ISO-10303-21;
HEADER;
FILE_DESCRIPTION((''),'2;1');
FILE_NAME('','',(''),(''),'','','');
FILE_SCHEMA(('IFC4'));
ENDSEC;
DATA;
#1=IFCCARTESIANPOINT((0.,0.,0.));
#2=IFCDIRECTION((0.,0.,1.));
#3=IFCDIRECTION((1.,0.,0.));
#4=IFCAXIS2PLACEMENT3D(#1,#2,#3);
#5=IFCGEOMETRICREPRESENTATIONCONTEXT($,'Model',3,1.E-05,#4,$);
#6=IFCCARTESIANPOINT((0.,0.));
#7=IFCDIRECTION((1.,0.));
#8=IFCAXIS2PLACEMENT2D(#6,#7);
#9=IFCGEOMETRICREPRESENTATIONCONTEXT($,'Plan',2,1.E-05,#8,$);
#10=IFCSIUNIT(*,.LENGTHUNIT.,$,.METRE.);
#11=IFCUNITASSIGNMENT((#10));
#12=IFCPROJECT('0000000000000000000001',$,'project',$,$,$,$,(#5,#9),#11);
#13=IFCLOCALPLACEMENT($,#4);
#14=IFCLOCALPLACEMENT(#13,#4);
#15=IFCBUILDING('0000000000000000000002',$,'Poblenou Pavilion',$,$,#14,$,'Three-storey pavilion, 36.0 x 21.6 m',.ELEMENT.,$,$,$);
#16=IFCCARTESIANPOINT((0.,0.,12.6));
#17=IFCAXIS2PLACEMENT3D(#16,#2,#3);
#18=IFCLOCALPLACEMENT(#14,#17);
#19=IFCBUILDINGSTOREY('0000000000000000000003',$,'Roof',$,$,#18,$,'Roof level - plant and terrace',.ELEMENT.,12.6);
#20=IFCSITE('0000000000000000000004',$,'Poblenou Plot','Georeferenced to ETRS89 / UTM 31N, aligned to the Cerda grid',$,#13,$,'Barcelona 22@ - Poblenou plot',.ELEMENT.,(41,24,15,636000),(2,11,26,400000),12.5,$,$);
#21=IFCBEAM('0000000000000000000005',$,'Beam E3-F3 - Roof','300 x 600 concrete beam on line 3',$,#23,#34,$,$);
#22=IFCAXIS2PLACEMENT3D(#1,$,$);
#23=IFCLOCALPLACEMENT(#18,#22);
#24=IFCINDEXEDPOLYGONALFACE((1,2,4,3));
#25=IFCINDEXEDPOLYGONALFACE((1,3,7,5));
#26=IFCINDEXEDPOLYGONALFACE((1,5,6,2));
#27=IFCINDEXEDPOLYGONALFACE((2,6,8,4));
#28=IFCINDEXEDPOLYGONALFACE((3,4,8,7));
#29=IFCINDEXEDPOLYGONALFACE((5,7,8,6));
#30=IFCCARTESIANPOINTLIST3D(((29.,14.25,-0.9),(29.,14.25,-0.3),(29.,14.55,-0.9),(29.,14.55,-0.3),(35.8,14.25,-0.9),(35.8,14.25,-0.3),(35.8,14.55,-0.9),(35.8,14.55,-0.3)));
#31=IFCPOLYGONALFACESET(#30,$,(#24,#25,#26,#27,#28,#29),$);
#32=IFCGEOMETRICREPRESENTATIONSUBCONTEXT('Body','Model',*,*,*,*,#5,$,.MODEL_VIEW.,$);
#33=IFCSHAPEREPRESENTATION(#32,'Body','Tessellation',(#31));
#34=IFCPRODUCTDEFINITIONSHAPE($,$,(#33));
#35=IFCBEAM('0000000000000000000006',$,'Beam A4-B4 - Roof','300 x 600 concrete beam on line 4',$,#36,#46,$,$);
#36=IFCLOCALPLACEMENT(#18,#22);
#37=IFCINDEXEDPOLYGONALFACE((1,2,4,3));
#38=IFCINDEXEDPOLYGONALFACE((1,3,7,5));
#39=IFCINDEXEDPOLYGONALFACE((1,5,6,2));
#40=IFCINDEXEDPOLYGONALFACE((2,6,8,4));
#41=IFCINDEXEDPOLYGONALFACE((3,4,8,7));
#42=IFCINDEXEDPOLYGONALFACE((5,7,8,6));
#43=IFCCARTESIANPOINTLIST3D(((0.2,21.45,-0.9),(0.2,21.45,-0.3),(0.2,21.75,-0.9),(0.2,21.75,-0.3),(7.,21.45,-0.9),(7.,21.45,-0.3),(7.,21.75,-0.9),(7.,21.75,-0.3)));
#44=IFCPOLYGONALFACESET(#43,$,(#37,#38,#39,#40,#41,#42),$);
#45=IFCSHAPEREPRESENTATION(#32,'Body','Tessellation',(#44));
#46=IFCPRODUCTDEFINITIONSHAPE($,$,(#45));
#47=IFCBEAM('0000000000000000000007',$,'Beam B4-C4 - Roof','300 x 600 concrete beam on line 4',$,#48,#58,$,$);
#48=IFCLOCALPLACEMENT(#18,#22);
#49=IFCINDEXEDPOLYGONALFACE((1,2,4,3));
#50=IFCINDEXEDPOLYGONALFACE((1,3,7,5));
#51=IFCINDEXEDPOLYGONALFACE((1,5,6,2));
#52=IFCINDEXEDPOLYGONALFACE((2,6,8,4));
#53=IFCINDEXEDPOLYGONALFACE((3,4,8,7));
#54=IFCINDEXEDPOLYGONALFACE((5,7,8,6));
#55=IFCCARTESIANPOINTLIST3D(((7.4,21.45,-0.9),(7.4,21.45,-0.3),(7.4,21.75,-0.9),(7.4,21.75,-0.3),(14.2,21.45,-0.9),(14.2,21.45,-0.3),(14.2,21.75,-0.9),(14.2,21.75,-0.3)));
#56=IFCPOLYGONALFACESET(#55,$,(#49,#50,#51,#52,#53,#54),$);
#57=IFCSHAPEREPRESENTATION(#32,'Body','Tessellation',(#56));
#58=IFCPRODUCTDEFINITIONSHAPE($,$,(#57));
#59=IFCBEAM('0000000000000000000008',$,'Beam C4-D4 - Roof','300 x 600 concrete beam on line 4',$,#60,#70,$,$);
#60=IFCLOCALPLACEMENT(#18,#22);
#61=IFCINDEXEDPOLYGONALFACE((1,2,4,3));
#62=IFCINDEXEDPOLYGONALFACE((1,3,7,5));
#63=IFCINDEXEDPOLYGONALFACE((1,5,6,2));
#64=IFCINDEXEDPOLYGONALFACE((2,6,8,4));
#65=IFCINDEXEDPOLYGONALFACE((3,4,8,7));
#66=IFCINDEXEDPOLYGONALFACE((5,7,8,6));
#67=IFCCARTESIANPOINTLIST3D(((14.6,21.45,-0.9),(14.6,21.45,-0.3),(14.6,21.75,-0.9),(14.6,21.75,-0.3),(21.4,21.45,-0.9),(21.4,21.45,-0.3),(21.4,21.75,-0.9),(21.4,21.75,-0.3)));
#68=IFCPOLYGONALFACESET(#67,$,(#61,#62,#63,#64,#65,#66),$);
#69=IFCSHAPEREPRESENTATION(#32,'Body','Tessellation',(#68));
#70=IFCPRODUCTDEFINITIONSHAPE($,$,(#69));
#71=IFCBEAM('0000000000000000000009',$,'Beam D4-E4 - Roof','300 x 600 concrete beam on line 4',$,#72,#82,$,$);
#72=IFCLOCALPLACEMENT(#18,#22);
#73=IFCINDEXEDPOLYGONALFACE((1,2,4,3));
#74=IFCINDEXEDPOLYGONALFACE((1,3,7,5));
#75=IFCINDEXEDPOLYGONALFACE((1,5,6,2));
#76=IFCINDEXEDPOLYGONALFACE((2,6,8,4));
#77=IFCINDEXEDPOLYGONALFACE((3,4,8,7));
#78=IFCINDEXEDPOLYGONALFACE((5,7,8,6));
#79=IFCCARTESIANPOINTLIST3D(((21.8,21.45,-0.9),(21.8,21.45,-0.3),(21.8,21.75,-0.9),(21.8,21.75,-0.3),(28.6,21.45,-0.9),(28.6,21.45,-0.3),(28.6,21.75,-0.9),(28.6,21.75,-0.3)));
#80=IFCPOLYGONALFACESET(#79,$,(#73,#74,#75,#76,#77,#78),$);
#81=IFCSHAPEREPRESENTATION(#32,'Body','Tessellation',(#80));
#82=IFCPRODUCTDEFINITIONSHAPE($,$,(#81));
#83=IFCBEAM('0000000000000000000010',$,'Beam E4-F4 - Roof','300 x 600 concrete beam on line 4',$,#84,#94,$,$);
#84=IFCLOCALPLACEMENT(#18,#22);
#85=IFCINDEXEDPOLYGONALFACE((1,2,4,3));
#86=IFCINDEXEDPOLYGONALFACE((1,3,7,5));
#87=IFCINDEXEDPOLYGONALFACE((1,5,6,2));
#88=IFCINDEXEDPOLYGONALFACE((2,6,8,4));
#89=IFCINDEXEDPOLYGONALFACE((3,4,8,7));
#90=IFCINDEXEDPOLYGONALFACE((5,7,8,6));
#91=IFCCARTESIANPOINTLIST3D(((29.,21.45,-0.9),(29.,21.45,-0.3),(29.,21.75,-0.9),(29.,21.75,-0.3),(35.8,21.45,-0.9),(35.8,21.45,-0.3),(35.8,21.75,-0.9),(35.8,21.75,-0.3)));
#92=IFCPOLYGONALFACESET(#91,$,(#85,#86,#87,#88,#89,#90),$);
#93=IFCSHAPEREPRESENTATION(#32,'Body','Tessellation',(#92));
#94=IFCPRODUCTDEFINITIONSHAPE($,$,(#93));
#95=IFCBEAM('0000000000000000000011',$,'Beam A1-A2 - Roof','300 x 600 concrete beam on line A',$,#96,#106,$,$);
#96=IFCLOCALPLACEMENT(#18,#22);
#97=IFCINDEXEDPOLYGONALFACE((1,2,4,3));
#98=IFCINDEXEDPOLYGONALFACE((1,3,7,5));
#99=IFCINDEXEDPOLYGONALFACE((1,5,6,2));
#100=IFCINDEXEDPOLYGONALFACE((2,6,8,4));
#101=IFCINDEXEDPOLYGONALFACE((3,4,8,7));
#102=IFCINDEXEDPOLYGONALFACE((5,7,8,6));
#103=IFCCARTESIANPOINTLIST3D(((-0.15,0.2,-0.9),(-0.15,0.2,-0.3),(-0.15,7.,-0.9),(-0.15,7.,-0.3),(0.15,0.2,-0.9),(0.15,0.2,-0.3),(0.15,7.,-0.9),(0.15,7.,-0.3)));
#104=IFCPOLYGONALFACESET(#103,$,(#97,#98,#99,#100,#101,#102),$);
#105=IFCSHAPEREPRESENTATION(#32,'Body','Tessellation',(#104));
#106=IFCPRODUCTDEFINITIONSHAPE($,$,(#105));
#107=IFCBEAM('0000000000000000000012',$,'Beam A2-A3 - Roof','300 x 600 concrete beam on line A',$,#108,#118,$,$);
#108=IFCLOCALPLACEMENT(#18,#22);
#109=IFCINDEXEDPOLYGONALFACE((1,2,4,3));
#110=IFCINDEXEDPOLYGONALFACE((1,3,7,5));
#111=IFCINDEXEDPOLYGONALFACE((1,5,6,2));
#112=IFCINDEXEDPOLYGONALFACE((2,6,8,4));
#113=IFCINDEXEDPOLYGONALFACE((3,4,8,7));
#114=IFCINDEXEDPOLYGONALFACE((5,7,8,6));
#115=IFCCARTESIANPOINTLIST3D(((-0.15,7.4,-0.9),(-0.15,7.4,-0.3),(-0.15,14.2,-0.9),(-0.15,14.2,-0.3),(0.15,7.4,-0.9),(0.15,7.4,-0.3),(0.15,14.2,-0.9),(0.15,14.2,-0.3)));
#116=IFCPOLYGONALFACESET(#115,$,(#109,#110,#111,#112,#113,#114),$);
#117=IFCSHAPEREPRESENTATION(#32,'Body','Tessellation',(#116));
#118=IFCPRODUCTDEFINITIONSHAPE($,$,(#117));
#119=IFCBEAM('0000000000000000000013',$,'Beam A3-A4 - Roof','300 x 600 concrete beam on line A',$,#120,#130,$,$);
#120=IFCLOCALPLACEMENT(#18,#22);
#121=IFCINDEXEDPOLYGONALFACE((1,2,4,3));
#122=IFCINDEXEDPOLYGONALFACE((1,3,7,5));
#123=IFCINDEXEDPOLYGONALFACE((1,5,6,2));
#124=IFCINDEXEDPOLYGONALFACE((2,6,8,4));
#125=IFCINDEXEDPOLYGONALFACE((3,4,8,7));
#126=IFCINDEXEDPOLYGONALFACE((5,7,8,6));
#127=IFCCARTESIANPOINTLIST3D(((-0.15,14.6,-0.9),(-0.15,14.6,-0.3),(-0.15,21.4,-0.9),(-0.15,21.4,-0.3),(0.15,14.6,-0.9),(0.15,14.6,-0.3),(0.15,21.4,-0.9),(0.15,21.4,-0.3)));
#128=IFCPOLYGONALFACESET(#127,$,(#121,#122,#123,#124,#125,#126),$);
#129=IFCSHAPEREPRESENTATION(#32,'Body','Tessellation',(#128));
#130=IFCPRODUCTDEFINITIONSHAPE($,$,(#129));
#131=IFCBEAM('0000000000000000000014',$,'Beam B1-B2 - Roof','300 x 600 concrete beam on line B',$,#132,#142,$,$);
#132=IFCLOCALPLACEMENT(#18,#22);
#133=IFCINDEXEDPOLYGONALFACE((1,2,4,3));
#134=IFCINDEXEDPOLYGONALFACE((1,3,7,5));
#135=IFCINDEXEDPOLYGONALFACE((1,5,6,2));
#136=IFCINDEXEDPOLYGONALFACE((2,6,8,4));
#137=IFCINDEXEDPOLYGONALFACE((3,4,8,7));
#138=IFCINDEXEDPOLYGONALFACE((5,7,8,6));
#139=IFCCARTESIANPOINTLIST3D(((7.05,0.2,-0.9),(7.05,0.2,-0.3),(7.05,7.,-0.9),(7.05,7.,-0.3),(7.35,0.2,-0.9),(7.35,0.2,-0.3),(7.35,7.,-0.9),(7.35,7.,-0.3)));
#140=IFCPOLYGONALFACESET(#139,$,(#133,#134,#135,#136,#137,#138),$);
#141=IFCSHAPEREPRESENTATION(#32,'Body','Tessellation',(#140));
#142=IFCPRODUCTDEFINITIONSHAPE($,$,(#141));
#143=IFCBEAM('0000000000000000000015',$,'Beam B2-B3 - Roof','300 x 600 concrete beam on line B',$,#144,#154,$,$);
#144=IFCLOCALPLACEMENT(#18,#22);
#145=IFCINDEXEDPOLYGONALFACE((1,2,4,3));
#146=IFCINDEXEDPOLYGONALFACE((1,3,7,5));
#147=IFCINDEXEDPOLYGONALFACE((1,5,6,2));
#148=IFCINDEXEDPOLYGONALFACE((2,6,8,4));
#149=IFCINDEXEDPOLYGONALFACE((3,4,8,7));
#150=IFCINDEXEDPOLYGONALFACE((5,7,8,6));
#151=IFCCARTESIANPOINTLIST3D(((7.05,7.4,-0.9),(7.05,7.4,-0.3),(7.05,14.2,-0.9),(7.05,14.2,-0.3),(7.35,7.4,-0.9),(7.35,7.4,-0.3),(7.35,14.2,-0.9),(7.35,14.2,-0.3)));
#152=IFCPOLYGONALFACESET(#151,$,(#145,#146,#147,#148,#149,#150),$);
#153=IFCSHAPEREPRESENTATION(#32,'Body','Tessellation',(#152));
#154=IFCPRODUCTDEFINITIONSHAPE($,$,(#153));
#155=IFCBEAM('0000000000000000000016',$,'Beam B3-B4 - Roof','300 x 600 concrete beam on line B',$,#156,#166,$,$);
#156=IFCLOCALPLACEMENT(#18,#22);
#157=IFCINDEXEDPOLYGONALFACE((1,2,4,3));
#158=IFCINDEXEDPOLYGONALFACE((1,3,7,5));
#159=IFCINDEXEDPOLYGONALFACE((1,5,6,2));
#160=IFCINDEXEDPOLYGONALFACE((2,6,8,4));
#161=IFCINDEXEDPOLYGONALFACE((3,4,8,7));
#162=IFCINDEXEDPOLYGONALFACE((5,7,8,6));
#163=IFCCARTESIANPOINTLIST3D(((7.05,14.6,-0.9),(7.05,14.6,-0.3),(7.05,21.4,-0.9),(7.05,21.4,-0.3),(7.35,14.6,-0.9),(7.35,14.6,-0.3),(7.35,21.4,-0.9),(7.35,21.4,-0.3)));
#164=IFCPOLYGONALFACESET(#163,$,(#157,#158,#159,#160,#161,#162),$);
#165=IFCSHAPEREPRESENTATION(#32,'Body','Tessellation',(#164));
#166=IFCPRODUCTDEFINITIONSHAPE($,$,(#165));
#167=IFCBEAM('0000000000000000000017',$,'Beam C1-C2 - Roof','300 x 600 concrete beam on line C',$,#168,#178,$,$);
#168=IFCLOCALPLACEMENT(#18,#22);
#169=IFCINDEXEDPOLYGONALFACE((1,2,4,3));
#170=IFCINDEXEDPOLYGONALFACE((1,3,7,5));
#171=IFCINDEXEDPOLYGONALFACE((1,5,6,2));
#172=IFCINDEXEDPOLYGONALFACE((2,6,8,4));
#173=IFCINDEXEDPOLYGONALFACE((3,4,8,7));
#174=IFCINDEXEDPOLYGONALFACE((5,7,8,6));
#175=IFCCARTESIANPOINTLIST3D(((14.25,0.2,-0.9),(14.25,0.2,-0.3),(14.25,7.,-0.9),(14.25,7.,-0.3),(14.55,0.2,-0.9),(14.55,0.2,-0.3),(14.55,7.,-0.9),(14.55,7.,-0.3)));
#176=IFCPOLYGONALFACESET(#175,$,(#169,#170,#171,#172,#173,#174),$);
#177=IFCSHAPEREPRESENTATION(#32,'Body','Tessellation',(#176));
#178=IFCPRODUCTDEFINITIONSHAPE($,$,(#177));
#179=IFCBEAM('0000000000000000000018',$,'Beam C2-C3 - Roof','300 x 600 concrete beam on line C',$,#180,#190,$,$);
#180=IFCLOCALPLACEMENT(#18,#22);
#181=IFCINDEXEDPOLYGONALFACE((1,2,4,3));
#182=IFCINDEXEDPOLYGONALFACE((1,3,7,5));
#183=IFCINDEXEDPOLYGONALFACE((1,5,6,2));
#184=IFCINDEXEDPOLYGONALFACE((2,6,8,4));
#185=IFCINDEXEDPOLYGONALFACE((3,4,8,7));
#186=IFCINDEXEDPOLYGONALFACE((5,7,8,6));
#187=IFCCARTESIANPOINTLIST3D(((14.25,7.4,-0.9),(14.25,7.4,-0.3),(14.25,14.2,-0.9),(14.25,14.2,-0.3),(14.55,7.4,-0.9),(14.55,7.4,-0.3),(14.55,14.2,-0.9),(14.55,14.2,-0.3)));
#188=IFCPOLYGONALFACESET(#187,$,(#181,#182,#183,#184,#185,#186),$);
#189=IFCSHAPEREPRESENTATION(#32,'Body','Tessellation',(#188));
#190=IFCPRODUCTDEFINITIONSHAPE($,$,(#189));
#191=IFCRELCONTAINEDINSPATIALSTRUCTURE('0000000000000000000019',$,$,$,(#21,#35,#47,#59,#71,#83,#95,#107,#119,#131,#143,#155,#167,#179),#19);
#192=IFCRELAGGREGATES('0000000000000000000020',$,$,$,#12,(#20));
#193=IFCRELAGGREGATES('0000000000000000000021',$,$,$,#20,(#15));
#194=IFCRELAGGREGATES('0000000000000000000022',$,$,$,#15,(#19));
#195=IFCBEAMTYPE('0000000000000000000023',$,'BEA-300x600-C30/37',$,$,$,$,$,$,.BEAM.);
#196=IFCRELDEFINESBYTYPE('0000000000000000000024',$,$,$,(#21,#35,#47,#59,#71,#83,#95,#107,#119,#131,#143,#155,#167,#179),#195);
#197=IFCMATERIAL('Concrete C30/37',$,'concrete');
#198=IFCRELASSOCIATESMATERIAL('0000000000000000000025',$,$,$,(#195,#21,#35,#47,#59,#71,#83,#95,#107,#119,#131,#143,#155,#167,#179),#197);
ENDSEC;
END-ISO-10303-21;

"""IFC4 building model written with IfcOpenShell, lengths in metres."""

from ifc_helpers import new_model, si_unit, frame, origin_with_axes, origin_2d_with_axis, place, context, subcontext, project, spatial, line, indexed_curve, rectangle, outline, extrude, material, material_profile, profile_set, profile_usage, type_object, element, save


model = new_model("IFC4")

# Units and contexts
model_context = context("Model", 3, precision=1e-05, world=origin_with_axes())
plan_context = context("Plan", 2, precision=1e-05, world=origin_2d_with_axis())
body_context = subcontext(model_context, "Body", "Model", "MODEL_VIEW")
ifc_project = project(units=[si_unit("LENGTHUNIT", "METRE")], contexts=[model_context, plan_context])

# Site, building, storey
site_placement = place(None, origin_with_axes())
site = spatial("IfcSite", under=ifc_project, at=site_placement, Name="Poblenou Plot", Description="Georeferenced to ETRS89 / UTM 31N, aligned to the Cerda grid", LongName="Barcelona 22@ - Poblenou plot", CompositionType="ELEMENT", RefLatitude=(41, 24, 15, 636000), RefLongitude=(2, 11, 26, 400000), RefElevation=12.5)
building_placement = place(site_placement, origin_with_axes())
building = spatial("IfcBuilding", under=site, at=building_placement, Name="Poblenou Pavilion", LongName="Three-storey pavilion, 36.0 x 21.6 m", CompositionType="ELEMENT")
storey_placement = place(building_placement, frame((0.0, 0.0, 12.6), z_axis=(0.0, 0.0, 1.0), x_axis=(1.0, 0.0, 0.0)))
storey = spatial("IfcBuildingStorey", under=building, at=storey_placement, Name="Roof", LongName="Roof level - plant and terrace", CompositionType="ELEMENT", Elevation=12.6)

# Beams
ifc_material = material(Name="Concrete C30/37", Category="concrete")
ifc_material_profile = material_profile(ifc_material, rectangle(XDim=0.3, YDim=0.6))
ifc_profile_set = profile_set([ifc_material_profile], Name="BEA-300x600-C30/37")
beam_type = type_object("IfcBeamType", Name="BEA-300x600-C30/37", PredefinedType="BEAM", material=ifc_profile_set)
ifc_profile_usage_1 = profile_usage(ifc_profile_set)
beam_1_placement = place(storey_placement, frame((29.0, 14.25, -0.9), z_axis=(1.0, 0.0, 0.0), x_axis=(0.0, 1.0, 0.0)))
element("IfcBeam", 1, at=beam_1_placement, inside=storey, type_object=beam_type, material=ifc_profile_usage_1, Name="Beam E3-F3 - Roof", Description="300 x 600 concrete beam on line 3", context=body_context, shape_type="SweptSolid", body=[
    extrude(outline(indexed_curve([(0.0, 0.0), (0.3, 0.0), (0.3, 0.6), (0.0, 0.6)], segments=[line(1, 2, 3, 4, 1)])), origin_with_axes(), (0.0, 0.0, 1.0), 6.8),
])
ifc_profile_usage_2 = profile_usage(ifc_profile_set)
beam_2_placement = place(storey_placement, frame((0.2, 21.45, -0.9), z_axis=(1.0, 0.0, 0.0), x_axis=(0.0, 1.0, 0.0)))
element("IfcBeam", 2, at=beam_2_placement, inside=storey, type_object=beam_type, material=ifc_profile_usage_2, Name="Beam A4-B4 - Roof", Description="300 x 600 concrete beam on line 4", context=body_context, shape_type="SweptSolid", body=[
    extrude(outline(indexed_curve([(0.0, 0.0), (0.3, 0.0), (0.3, 0.6), (0.0, 0.6)], segments=[line(1, 2, 3, 4, 1)])), origin_with_axes(), (0.0, 0.0, 1.0), 6.8),
])
ifc_profile_usage_3 = profile_usage(ifc_profile_set)
beam_3_placement = place(storey_placement, frame((7.4, 21.45, -0.9), z_axis=(1.0, 0.0, 0.0), x_axis=(0.0, 1.0, 0.0)))
element("IfcBeam", 3, at=beam_3_placement, inside=storey, type_object=beam_type, material=ifc_profile_usage_3, Name="Beam B4-C4 - Roof", Description="300 x 600 concrete beam on line 4", context=body_context, shape_type="SweptSolid", body=[
    extrude(outline(indexed_curve([(0.0, 0.0), (0.3, 0.0), (0.3, 0.6), (0.0, 0.6)], segments=[line(1, 2, 3, 4, 1)])), origin_with_axes(), (0.0, 0.0, 1.0), 6.8),
])
ifc_profile_usage_4 = profile_usage(ifc_profile_set)
beam_4_placement = place(storey_placement, frame((14.6, 21.45, -0.9), z_axis=(1.0, 0.0, 0.0), x_axis=(0.0, 1.0, 0.0)))
element("IfcBeam", 4, at=beam_4_placement, inside=storey, type_object=beam_type, material=ifc_profile_usage_4, Name="Beam C4-D4 - Roof", Description="300 x 600 concrete beam on line 4", context=body_context, shape_type="SweptSolid", body=[
    extrude(outline(indexed_curve([(0.0, 0.0), (0.3, 0.0), (0.3, 0.6), (0.0, 0.6)], segments=[line(1, 2, 3, 4, 1)])), origin_with_axes(), (0.0, 0.0, 1.0), 6.8),
])
ifc_profile_usage_5 = profile_usage(ifc_profile_set)
beam_5_placement = place(storey_placement, frame((21.8, 21.45, -0.9), z_axis=(1.0, 0.0, 0.0), x_axis=(0.0, 1.0, 0.0)))
element("IfcBeam", 5, at=beam_5_placement, inside=storey, type_object=beam_type, material=ifc_profile_usage_5, Name="Beam D4-E4 - Roof", Description="300 x 600 concrete beam on line 4", context=body_context, shape_type="SweptSolid", body=[
    extrude(outline(indexed_curve([(0.0, 0.0), (0.3, 0.0), (0.3, 0.6), (0.0, 0.6)], segments=[line(1, 2, 3, 4, 1)])), origin_with_axes(), (0.0, 0.0, 1.0), 6.8),
])
ifc_profile_usage_6 = profile_usage(ifc_profile_set)
beam_6_placement = place(storey_placement, frame((29.0, 21.45, -0.9), z_axis=(1.0, 0.0, 0.0), x_axis=(0.0, 1.0, 0.0)))
element("IfcBeam", 6, at=beam_6_placement, inside=storey, type_object=beam_type, material=ifc_profile_usage_6, Name="Beam E4-F4 - Roof", Description="300 x 600 concrete beam on line 4", context=body_context, shape_type="SweptSolid", body=[
    extrude(outline(indexed_curve([(0.0, 0.0), (0.3, 0.0), (0.3, 0.6), (0.0, 0.6)], segments=[line(1, 2, 3, 4, 1)])), origin_with_axes(), (0.0, 0.0, 1.0), 6.8),
])
ifc_profile_usage_7 = profile_usage(ifc_profile_set)
beam_7_placement = place(storey_placement, frame((-0.15, 0.2, -0.9), z_axis=(0.0, 1.0, 0.0), x_axis=(0.0, 0.0, 1.0)))
element("IfcBeam", 7, at=beam_7_placement, inside=storey, type_object=beam_type, material=ifc_profile_usage_7, Name="Beam A1-A2 - Roof", Description="300 x 600 concrete beam on line A", context=body_context, shape_type="SweptSolid", body=[
    extrude(outline(indexed_curve([(0.0, 0.0), (0.6, 0.0), (0.6, 0.3), (0.0, 0.3)], segments=[line(1, 2, 3, 4, 1)])), origin_with_axes(), (0.0, 0.0, 1.0), 6.8),
])
ifc_profile_usage_8 = profile_usage(ifc_profile_set)
beam_8_placement = place(storey_placement, frame((-0.15, 7.4, -0.9), z_axis=(0.0, 1.0, 0.0), x_axis=(0.0, 0.0, 1.0)))
element("IfcBeam", 8, at=beam_8_placement, inside=storey, type_object=beam_type, material=ifc_profile_usage_8, Name="Beam A2-A3 - Roof", Description="300 x 600 concrete beam on line A", context=body_context, shape_type="SweptSolid", body=[
    extrude(outline(indexed_curve([(0.0, 0.0), (0.6, 0.0), (0.6, 0.3), (0.0, 0.3)], segments=[line(1, 2, 3, 4, 1)])), origin_with_axes(), (0.0, 0.0, 1.0), 6.8),
])
ifc_profile_usage_9 = profile_usage(ifc_profile_set)
beam_9_placement = place(storey_placement, frame((-0.15, 14.6, -0.9), z_axis=(0.0, 1.0, 0.0), x_axis=(0.0, 0.0, 1.0)))
element("IfcBeam", 9, at=beam_9_placement, inside=storey, type_object=beam_type, material=ifc_profile_usage_9, Name="Beam A3-A4 - Roof", Description="300 x 600 concrete beam on line A", context=body_context, shape_type="SweptSolid", body=[
    extrude(outline(indexed_curve([(0.0, 0.0), (0.6, 0.0), (0.6, 0.3), (0.0, 0.3)], segments=[line(1, 2, 3, 4, 1)])), origin_with_axes(), (0.0, 0.0, 1.0), 6.8),
])
ifc_profile_usage_10 = profile_usage(ifc_profile_set)
beam_10_placement = place(storey_placement, frame((7.05, 0.2, -0.9), z_axis=(0.0, 1.0, 0.0), x_axis=(0.0, 0.0, 1.0)))
element("IfcBeam", 10, at=beam_10_placement, inside=storey, type_object=beam_type, material=ifc_profile_usage_10, Name="Beam B1-B2 - Roof", Description="300 x 600 concrete beam on line B", context=body_context, shape_type="SweptSolid", body=[
    extrude(outline(indexed_curve([(0.0, 0.0), (0.6, 0.0), (0.6, 0.3), (0.0, 0.3)], segments=[line(1, 2, 3, 4, 1)])), origin_with_axes(), (0.0, 0.0, 1.0), 6.8),
])
ifc_profile_usage_11 = profile_usage(ifc_profile_set)
beam_11_placement = place(storey_placement, frame((7.05, 7.4, -0.9), z_axis=(0.0, 1.0, 0.0), x_axis=(0.0, 0.0, 1.0)))
element("IfcBeam", 11, at=beam_11_placement, inside=storey, type_object=beam_type, material=ifc_profile_usage_11, Name="Beam B2-B3 - Roof", Description="300 x 600 concrete beam on line B", context=body_context, shape_type="SweptSolid", body=[
    extrude(outline(indexed_curve([(0.0, 0.0), (0.6, 0.0), (0.6, 0.3), (0.0, 0.3)], segments=[line(1, 2, 3, 4, 1)])), origin_with_axes(), (0.0, 0.0, 1.0), 6.8),
])
ifc_profile_usage_12 = profile_usage(ifc_profile_set)
beam_12_placement = place(storey_placement, frame((7.05, 14.6, -0.9), z_axis=(0.0, 1.0, 0.0), x_axis=(0.0, 0.0, 1.0)))
element("IfcBeam", 12, at=beam_12_placement, inside=storey, type_object=beam_type, material=ifc_profile_usage_12, Name="Beam B3-B4 - Roof", Description="300 x 600 concrete beam on line B", context=body_context, shape_type="SweptSolid", body=[
    extrude(outline(indexed_curve([(0.0, 0.0), (0.6, 0.0), (0.6, 0.3), (0.0, 0.3)], segments=[line(1, 2, 3, 4, 1)])), origin_with_axes(), (0.0, 0.0, 1.0), 6.8),
])
ifc_profile_usage_13 = profile_usage(ifc_profile_set)
beam_13_placement = place(storey_placement, frame((14.25, 0.2, -0.9), z_axis=(0.0, 1.0, 0.0), x_axis=(0.0, 0.0, 1.0)))
element("IfcBeam", 13, at=beam_13_placement, inside=storey, type_object=beam_type, material=ifc_profile_usage_13, Name="Beam C1-C2 - Roof", Description="300 x 600 concrete beam on line C", context=body_context, shape_type="SweptSolid", body=[
    extrude(outline(indexed_curve([(0.0, 0.0), (0.6, 0.0), (0.6, 0.3), (0.0, 0.3)], segments=[line(1, 2, 3, 4, 1)])), origin_with_axes(), (0.0, 0.0, 1.0), 6.8),
])
ifc_profile_usage_14 = profile_usage(ifc_profile_set)
beam_14_placement = place(storey_placement, frame((14.25, 7.4, -0.9), z_axis=(0.0, 1.0, 0.0), x_axis=(0.0, 0.0, 1.0)))
element("IfcBeam", 14, at=beam_14_placement, inside=storey, type_object=beam_type, material=ifc_profile_usage_14, Name="Beam C2-C3 - Roof", Description="300 x 600 concrete beam on line C", context=body_context, shape_type="SweptSolid", body=[
    extrude(outline(indexed_curve([(0.0, 0.0), (0.6, 0.0), (0.6, 0.3), (0.0, 0.3)], segments=[line(1, 2, 3, 4, 1)])), origin_with_axes(), (0.0, 0.0, 1.0), 6.8),
])

save(model, "model.ifc")
